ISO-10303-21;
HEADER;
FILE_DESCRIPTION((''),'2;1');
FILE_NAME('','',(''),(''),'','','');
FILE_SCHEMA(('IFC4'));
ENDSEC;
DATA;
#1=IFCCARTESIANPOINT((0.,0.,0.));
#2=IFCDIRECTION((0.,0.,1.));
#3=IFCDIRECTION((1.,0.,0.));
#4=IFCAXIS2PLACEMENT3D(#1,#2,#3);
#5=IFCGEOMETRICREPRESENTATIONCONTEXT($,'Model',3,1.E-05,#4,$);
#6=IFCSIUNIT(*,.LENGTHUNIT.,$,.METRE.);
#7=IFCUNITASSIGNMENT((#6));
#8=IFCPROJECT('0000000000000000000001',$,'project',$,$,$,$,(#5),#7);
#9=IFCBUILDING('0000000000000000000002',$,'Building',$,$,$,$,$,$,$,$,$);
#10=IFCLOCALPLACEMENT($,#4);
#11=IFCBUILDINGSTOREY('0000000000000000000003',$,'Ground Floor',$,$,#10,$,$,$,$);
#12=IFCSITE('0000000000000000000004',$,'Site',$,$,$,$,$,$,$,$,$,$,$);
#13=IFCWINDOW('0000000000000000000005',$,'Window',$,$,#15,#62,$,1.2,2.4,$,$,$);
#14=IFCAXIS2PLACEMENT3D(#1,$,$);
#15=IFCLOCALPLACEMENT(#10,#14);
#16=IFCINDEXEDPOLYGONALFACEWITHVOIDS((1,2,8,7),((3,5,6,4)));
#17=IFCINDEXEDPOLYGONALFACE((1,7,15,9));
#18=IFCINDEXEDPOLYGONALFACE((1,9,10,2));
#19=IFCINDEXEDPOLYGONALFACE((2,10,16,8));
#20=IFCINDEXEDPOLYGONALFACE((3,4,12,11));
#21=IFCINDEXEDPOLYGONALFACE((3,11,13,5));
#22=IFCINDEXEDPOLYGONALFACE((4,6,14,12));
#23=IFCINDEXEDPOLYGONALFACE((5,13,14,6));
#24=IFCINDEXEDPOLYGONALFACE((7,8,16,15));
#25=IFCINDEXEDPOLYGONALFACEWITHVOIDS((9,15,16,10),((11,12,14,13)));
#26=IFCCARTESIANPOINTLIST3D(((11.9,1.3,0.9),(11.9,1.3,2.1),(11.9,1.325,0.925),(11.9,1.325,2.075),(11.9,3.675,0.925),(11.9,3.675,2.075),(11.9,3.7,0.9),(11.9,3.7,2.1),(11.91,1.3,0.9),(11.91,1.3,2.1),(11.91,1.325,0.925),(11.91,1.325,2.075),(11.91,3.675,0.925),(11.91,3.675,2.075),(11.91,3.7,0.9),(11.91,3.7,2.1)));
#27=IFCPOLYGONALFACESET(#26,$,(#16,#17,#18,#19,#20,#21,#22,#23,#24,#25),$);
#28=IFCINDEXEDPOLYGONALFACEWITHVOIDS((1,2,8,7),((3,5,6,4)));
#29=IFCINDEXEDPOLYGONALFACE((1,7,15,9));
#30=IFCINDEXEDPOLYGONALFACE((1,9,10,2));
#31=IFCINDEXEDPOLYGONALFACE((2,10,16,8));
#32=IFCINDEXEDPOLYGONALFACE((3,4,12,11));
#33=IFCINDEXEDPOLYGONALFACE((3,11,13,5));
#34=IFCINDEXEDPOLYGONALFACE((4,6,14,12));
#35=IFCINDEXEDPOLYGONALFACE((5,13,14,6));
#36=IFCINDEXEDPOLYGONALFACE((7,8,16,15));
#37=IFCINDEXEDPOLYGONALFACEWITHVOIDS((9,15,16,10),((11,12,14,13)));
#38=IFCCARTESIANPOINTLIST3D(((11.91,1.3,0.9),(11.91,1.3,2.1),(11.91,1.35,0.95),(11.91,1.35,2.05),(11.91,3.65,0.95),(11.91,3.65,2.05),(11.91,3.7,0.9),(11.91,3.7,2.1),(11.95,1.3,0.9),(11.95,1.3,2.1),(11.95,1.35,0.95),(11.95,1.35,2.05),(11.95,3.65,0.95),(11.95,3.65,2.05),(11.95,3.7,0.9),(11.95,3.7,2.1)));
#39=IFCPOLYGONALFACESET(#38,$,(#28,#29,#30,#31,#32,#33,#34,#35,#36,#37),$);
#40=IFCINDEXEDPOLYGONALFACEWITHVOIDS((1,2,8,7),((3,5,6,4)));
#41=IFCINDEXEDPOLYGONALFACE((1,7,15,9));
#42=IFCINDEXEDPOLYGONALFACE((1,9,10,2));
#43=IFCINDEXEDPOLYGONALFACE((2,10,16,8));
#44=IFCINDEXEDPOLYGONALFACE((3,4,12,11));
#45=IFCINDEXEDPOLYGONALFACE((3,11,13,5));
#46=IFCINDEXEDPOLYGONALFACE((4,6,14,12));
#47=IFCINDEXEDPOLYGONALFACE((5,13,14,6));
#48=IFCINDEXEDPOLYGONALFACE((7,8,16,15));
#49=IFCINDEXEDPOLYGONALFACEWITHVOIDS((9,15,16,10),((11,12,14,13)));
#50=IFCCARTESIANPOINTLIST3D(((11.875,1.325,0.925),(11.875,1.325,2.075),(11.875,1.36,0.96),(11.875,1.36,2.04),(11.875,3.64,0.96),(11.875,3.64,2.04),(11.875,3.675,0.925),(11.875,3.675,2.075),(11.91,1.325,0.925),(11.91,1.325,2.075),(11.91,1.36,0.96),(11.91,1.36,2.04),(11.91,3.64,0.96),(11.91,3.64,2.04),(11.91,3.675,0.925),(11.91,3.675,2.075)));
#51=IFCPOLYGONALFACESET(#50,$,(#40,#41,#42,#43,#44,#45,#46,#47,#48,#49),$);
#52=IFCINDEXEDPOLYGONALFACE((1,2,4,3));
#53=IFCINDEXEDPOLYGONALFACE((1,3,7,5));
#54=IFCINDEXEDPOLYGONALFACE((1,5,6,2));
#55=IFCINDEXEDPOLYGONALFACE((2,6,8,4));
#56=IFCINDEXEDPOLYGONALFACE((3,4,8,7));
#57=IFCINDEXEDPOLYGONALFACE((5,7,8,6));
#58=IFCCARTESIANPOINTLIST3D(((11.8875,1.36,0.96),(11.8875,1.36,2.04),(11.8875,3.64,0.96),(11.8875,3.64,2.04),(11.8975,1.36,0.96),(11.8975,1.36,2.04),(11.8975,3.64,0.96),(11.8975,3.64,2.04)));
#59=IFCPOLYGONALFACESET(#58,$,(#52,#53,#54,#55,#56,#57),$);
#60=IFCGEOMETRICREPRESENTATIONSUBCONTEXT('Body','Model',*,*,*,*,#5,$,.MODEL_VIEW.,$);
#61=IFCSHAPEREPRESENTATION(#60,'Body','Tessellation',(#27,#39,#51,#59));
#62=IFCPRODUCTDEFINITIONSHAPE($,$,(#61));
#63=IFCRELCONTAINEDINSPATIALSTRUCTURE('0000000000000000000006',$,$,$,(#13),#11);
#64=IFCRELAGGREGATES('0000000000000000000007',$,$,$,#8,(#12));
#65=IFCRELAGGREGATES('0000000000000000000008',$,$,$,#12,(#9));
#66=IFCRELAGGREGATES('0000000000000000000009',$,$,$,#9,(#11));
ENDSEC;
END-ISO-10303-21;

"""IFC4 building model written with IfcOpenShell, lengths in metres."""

from ifc_helpers import new_model, si_unit, frame, origin_with_axes, place, context, subcontext, project, spatial, line, indexed_curve, outline, extrude, element, save


model = new_model("IFC4")

# Units and contexts
model_context = context("Model", 3, precision=1e-05, world=origin_with_axes())
body_context = subcontext(model_context, "Body", "Model", "MODEL_VIEW")
ifc_project = project(units=[si_unit("LENGTHUNIT", "METRE")], contexts=[model_context])

# Site, building, storey
site = spatial("IfcSite", under=ifc_project, Name="Site")
building = spatial("IfcBuilding", under=site, Name="Building")
storey_placement = place(None, origin_with_axes())
storey = spatial("IfcBuildingStorey", under=building, at=storey_placement, Name="Ground Floor")

# Window
window_1_placement = place(storey_placement, frame((12.0, 1.3, 0.9), z_axis=(0.0, 0.0, 1.0), x_axis=(0.0, 1.0, 0.0)))
element("IfcWindow", 1, at=window_1_placement, inside=storey, Name="Window", OverallHeight=1.2, OverallWidth=2.4, context=body_context, shape_type="SweptSolid", body=[
    extrude(outline(indexed_curve([(0.0, 0.0), (2.4, 0.0), (2.4, 1.2), (0.0, 1.2)], segments=[line(1, 2, 3, 4, 1)]), holes=[indexed_curve([(0.025, 0.025), (2.375, 0.025), (2.375, 1.175), (0.025, 1.175)], segments=[line(1, 2, 3, 4, 1)])]), frame((0.0, 0.09, 0.0), z_axis=(0.0, -1.0, 0.0), x_axis=(1.0, 0.0, 0.0)), (0.0, 0.0, -1.0), 0.01),
    extrude(outline(indexed_curve([(0.0, 0.0), (2.4, 0.0), (2.4, 1.2), (0.0, 1.2)], segments=[line(1, 2, 3, 4, 1)]), holes=[indexed_curve([(0.05, 0.05), (2.35, 0.05), (2.35, 1.15), (0.05, 1.15)], segments=[line(1, 2, 3, 4, 1)])]), frame((0.0, 0.05, 0.0), z_axis=(0.0, -1.0, 0.0), x_axis=(1.0, 0.0, 0.0)), (0.0, 0.0, -1.0), 0.04),
    extrude(outline(indexed_curve([(0.0, 0.0), (2.35, 0.0), (2.35, 1.15), (0.0, 1.15)], segments=[line(1, 2, 3, 4, 1)]), holes=[indexed_curve([(0.035, 0.035), (2.315, 0.035), (2.315, 1.115), (0.035, 1.115)], segments=[line(1, 2, 3, 4, 1)])]), frame((0.025, 0.09, 0.025), z_axis=(0.0, -1.0, 0.0), x_axis=(1.0, 0.0, 0.0)), (0.0, 0.0, -1.0), 0.035),
    extrude(outline(indexed_curve([(0.035, 0.035), (2.315, 0.035), (2.315, 1.115), (0.035, 1.115)], segments=[line(1, 2, 3, 4, 1)])), frame((0.025, 0.1025, 0.025), z_axis=(0.0, -1.0, 0.0), x_axis=(1.0, 0.0, 0.0)), (0.0, 0.0, -1.0), 0.01),
])

save(model, "model.ifc")
